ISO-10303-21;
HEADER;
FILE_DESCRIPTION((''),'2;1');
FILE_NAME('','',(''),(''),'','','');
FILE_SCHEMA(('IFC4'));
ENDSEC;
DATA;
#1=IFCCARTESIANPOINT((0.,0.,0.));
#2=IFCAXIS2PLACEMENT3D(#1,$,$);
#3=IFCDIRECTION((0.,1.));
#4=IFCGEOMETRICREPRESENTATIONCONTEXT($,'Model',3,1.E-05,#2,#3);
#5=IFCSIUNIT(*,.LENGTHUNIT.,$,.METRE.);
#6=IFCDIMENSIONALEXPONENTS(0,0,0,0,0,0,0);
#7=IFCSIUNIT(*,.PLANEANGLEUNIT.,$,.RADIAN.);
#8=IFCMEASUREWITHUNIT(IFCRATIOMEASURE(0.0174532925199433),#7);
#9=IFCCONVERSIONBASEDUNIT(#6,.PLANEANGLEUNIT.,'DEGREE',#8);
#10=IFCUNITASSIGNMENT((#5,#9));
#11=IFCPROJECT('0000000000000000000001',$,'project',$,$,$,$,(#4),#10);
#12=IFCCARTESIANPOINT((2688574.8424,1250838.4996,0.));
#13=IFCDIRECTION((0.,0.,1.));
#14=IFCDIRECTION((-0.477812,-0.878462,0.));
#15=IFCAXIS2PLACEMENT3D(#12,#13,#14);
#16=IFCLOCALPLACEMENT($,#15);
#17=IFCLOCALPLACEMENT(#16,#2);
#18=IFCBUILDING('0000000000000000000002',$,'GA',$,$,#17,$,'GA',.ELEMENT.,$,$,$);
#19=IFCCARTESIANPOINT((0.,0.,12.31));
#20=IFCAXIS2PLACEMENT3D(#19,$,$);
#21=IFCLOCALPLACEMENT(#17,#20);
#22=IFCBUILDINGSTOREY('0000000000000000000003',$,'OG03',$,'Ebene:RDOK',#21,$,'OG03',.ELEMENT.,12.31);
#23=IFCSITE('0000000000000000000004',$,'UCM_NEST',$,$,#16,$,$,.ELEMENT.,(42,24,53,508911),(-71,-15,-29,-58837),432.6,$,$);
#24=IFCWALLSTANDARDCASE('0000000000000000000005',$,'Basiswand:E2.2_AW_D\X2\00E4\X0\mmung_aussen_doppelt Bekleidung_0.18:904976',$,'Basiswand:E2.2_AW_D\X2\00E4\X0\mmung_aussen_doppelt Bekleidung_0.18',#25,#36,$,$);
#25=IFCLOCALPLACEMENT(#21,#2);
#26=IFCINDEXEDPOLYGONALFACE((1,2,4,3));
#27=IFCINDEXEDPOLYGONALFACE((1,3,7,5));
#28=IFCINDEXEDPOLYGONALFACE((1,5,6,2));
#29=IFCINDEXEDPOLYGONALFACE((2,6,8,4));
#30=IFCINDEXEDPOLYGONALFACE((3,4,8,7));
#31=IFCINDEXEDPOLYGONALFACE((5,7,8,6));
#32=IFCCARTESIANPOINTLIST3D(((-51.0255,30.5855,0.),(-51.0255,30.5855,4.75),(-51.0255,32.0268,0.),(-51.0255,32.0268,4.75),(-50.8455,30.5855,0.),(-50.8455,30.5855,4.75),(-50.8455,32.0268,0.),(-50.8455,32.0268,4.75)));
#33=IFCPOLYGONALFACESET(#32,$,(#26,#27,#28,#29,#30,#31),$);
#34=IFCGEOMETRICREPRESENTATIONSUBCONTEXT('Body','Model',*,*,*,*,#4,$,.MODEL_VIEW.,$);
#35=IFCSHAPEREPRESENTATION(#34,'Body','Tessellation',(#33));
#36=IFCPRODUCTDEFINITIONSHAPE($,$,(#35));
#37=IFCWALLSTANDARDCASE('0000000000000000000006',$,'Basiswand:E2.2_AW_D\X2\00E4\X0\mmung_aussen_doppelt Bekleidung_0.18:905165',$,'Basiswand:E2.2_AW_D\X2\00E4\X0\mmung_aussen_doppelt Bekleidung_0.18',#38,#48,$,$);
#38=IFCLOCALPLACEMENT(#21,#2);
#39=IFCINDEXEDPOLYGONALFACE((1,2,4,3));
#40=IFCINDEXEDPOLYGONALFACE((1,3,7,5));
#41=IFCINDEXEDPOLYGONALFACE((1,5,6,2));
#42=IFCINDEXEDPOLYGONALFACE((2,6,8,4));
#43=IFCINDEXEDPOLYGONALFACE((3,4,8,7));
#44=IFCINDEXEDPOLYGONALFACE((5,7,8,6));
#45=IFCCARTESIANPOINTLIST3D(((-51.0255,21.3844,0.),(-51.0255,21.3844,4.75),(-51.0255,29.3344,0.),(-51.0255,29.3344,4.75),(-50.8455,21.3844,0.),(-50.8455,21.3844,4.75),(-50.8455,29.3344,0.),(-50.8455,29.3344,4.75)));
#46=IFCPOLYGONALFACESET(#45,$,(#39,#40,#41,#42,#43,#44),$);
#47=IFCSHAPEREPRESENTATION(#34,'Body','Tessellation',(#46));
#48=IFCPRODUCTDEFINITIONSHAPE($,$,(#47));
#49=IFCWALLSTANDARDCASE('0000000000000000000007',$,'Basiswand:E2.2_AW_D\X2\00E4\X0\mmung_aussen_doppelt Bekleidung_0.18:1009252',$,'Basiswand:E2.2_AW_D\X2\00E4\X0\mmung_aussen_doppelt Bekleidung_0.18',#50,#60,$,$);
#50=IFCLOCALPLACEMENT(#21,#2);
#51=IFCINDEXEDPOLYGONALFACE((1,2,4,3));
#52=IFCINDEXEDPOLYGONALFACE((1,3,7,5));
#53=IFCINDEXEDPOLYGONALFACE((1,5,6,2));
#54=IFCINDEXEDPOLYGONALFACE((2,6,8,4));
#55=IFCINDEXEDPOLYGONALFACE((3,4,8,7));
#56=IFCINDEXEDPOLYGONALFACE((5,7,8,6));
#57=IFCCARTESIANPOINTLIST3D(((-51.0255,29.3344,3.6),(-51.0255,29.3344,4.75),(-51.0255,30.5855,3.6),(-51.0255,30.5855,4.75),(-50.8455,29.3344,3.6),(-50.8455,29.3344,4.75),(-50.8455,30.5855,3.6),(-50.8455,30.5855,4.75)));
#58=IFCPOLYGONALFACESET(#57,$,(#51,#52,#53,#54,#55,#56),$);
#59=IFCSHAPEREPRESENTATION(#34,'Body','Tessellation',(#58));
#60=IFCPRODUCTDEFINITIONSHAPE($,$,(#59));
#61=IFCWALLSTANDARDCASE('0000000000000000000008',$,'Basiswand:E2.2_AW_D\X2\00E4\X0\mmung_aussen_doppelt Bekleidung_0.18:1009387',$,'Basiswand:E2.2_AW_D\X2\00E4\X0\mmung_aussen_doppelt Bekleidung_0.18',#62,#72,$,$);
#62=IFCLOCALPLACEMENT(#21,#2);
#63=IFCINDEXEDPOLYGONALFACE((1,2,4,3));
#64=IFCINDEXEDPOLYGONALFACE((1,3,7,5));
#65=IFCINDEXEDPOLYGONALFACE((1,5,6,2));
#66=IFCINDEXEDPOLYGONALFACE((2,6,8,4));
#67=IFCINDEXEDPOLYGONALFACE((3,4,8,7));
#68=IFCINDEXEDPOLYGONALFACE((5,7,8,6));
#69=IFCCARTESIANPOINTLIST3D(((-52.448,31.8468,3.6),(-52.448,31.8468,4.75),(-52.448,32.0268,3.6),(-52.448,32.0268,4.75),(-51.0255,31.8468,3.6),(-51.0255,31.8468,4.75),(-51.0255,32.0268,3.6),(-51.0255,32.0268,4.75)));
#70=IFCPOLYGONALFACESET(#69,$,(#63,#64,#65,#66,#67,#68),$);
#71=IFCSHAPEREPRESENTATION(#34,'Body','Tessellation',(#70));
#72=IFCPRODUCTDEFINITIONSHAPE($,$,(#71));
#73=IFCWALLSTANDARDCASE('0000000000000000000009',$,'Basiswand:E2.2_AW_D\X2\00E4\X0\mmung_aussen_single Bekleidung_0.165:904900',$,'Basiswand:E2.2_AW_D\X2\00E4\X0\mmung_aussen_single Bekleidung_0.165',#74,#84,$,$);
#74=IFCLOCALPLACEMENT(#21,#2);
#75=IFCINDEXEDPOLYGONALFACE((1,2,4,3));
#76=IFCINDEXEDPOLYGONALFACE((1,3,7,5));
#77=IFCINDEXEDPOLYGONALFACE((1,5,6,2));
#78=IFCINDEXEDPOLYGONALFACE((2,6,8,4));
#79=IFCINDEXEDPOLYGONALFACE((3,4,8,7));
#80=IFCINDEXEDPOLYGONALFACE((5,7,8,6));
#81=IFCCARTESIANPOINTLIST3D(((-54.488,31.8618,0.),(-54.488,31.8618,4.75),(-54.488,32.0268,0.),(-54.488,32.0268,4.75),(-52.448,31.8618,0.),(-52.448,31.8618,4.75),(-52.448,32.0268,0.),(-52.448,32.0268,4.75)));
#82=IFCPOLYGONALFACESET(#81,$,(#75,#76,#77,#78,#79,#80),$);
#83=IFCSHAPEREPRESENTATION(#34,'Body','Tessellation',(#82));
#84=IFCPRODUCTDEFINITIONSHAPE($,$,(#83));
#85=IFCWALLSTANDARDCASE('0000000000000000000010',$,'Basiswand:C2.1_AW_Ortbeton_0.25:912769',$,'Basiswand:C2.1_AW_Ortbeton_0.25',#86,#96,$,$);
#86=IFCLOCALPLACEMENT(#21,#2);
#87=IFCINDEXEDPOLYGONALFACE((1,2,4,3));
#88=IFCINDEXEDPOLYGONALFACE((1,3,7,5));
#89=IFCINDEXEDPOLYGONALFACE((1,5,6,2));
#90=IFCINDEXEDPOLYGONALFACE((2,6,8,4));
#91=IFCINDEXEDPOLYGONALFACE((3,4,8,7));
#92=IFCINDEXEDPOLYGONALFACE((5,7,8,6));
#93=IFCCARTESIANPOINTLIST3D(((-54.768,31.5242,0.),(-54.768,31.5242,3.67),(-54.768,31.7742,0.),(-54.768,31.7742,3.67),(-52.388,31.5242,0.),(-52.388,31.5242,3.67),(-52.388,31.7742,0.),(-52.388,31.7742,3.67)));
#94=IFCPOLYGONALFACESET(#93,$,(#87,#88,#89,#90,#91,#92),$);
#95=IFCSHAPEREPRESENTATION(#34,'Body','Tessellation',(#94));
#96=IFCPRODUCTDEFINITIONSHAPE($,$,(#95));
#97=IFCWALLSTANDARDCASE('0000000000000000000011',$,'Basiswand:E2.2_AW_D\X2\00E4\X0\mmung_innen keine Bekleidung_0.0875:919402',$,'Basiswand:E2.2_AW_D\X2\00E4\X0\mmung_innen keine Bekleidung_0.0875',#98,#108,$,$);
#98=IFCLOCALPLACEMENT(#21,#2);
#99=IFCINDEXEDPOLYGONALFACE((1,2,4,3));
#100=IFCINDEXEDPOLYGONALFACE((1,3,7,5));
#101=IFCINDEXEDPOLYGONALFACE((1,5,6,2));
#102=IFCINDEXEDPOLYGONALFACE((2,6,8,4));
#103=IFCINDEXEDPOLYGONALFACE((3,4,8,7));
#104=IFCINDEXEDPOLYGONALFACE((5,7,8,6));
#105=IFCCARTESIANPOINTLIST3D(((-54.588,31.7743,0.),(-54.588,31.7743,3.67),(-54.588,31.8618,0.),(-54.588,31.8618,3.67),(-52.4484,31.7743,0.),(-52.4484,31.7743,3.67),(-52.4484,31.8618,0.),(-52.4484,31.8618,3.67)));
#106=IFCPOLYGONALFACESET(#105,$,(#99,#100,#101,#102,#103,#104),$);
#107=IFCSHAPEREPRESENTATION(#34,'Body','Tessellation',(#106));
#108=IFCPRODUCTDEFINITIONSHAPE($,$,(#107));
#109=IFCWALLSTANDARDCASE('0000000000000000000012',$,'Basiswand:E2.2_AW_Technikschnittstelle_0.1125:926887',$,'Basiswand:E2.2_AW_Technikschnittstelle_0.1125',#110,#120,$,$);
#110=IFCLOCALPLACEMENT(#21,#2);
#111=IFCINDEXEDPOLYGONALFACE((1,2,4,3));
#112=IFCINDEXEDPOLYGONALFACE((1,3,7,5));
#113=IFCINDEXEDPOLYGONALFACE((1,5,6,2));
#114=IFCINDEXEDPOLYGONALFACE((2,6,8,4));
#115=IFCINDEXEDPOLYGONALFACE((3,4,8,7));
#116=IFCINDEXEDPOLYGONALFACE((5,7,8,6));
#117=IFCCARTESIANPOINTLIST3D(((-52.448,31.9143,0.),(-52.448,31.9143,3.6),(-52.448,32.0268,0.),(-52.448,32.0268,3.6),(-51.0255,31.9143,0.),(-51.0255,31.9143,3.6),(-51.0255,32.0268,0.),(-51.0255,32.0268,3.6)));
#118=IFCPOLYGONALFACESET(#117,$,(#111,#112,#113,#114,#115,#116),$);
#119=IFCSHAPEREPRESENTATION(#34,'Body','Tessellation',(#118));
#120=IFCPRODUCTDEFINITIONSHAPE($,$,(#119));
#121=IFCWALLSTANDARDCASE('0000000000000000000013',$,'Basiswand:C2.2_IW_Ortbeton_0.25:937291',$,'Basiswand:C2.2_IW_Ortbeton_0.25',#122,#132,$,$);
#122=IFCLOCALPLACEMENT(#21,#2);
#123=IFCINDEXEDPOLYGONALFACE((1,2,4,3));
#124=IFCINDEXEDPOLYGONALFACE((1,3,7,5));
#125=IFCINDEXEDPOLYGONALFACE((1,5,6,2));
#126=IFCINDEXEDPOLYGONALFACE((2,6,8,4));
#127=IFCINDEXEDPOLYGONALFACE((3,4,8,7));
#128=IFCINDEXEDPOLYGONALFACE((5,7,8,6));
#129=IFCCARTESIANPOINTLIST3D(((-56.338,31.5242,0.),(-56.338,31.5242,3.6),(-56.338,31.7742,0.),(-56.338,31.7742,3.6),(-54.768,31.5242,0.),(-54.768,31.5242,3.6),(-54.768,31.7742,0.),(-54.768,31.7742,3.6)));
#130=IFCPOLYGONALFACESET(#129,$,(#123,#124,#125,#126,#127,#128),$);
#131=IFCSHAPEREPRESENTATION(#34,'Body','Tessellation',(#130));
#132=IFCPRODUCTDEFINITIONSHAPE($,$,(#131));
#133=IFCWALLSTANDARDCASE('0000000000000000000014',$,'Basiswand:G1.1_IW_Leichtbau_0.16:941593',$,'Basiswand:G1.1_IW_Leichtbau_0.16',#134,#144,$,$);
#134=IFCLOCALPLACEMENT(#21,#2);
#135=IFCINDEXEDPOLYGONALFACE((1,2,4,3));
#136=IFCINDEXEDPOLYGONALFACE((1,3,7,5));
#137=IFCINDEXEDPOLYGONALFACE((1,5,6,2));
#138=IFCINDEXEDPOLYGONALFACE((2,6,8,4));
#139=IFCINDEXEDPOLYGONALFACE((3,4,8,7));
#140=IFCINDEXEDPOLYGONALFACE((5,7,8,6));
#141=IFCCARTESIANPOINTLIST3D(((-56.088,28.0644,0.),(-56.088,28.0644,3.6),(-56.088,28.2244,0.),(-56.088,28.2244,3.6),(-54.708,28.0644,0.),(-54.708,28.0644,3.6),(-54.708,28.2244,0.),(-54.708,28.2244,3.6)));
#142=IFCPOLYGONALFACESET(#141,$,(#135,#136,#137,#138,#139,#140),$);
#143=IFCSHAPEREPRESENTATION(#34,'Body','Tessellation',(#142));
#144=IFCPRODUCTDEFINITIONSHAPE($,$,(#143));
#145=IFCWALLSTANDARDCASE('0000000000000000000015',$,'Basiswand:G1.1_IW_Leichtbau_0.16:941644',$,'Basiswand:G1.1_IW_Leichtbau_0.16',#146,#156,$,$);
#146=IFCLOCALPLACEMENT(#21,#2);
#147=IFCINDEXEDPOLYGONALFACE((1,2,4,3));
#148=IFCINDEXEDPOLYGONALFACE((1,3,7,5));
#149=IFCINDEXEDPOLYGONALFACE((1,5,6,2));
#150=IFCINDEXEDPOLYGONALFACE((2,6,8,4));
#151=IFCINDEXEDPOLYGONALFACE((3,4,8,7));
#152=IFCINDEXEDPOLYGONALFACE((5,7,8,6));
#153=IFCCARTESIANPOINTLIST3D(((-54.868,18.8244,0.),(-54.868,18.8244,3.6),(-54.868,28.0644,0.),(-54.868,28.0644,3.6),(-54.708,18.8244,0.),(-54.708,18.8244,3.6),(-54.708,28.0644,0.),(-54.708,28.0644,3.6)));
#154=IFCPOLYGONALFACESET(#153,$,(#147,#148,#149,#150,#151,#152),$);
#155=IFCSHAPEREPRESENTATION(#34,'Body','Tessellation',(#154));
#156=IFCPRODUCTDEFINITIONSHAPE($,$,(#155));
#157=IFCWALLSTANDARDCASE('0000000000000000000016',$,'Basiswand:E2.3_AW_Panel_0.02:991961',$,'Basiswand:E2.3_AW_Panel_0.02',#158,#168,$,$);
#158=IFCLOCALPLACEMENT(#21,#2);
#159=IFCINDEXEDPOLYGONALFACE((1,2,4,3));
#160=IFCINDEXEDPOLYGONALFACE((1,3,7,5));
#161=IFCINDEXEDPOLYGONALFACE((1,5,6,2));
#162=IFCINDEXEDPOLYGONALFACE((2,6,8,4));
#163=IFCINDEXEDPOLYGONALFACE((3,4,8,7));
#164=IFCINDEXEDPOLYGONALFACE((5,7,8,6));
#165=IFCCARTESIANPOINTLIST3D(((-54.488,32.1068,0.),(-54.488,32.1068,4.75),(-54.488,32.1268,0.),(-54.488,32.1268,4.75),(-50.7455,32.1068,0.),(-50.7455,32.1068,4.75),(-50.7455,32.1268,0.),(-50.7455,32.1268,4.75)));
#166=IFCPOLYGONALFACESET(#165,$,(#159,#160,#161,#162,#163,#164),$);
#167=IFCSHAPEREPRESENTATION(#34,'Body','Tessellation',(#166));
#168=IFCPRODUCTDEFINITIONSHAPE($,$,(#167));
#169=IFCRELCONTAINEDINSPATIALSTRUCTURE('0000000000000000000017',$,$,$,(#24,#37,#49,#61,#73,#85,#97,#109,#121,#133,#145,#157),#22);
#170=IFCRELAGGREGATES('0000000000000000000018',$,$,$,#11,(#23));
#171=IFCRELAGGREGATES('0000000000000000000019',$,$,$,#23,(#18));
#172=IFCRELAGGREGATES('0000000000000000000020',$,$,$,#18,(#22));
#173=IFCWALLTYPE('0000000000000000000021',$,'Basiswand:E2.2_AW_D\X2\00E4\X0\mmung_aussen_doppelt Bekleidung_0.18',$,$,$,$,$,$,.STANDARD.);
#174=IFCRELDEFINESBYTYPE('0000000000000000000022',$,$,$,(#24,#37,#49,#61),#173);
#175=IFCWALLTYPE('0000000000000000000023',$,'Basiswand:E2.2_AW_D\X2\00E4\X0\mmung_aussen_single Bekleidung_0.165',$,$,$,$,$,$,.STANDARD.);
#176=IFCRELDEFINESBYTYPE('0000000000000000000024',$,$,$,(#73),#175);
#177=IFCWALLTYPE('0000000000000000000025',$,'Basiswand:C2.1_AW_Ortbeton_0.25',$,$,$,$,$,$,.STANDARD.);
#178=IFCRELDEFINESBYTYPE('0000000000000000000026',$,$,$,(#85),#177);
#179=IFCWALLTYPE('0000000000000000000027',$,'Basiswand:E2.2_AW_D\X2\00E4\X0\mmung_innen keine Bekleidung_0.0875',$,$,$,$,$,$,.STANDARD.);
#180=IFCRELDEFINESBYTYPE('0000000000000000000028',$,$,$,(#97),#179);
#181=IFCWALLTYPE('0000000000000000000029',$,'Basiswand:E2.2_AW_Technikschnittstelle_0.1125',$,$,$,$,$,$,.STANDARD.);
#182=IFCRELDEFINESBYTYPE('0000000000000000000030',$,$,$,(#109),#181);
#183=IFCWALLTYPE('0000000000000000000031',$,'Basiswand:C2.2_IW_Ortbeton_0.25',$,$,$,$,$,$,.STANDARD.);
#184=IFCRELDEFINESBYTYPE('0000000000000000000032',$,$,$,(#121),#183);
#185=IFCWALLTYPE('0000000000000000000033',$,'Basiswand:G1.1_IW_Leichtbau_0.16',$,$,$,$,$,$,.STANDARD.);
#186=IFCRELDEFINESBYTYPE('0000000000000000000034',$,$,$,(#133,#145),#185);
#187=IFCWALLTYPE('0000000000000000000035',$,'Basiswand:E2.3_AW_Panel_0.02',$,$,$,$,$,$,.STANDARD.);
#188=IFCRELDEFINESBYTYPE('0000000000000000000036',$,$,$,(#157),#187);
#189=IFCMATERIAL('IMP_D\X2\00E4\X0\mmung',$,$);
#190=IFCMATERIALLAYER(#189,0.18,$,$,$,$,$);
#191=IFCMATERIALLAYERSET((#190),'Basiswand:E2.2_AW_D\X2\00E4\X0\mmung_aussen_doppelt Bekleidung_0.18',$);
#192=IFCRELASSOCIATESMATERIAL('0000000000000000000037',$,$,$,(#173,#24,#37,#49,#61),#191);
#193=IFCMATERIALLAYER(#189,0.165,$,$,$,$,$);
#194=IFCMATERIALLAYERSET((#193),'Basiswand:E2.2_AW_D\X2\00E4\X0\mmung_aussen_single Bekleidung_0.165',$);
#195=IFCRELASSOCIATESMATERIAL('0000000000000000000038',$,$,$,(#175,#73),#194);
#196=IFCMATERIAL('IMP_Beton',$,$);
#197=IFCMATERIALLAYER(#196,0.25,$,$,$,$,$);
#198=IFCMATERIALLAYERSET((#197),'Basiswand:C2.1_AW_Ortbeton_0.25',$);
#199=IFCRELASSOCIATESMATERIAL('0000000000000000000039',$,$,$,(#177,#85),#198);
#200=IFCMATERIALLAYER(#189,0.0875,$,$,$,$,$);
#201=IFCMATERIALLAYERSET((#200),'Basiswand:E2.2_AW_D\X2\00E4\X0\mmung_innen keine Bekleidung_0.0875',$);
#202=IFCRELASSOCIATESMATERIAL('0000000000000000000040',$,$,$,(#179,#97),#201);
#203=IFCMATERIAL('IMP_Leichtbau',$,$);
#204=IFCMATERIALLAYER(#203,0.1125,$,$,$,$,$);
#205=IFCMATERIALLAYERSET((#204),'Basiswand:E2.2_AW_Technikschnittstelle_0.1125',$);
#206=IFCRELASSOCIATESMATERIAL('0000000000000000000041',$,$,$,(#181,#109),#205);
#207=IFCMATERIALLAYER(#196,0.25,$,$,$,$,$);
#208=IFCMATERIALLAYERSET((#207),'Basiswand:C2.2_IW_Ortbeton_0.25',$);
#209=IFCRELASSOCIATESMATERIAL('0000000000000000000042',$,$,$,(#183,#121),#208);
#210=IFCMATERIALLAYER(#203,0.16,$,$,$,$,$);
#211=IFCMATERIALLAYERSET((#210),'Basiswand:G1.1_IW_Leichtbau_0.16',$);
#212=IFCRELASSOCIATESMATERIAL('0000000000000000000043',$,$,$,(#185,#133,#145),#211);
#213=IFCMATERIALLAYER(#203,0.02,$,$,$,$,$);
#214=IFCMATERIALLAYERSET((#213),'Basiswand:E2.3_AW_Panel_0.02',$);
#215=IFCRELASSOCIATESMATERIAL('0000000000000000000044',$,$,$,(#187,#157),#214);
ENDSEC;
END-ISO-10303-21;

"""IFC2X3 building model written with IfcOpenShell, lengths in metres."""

from ifc_helpers import new_model, entity, si_unit, converted_unit, direction, frame, frame_2d, origin, place, context, subcontext, project, spatial, rectangle, extrude, material, layer, layer_set, layer_usage, type_object, element, save


model = new_model("IFC2X3")

# Units and contexts
model_context = context("Model", 3, precision=1e-05, world=origin(), true_north=direction((0.0, 1.0)))
body_context = subcontext(model_context, "Body", "Model", "MODEL_VIEW")
ifc_project = project(units=[si_unit("LENGTHUNIT", "METRE"), converted_unit("PLANEANGLEUNIT", "DEGREE", entity("IfcRatioMeasure", 0.0174532925199433), si_unit("PLANEANGLEUNIT", "RADIAN"), dimensions=[0, 0, 0, 0, 0, 0, 0])], contexts=[model_context])

# Site, building, storey
site_placement = place(None, frame((2688574.8424, 1250838.4996, 0.0), z_axis=(0.0, 0.0, 1.0), x_axis=(-0.477812, -0.878462, 0.0)))
site = spatial("IfcSite", under=ifc_project, at=site_placement, Name="UCM_NEST", CompositionType="ELEMENT", RefLatitude=(42, 24, 53, 508911), RefLongitude=(-71, -15, -29, -58837), RefElevation=432.6)
building_placement = place(site_placement, origin())
building = spatial("IfcBuilding", under=site, at=building_placement, Name="GA", LongName="GA", CompositionType="ELEMENT")
storey_placement = place(building_placement, frame((0.0, 0.0, 12.31)))
storey = spatial("IfcBuildingStorey", under=building, at=storey_placement, Name="OG03", ObjectType="Ebene:RDOK", LongName="OG03", CompositionType="ELEMENT", Elevation=12.31)

# Walls
ifc_material_1 = material(Name="IMP_Dämmung")
ifc_layer_1 = layer(ifc_material_1, 0.18)
ifc_layer_set_1 = layer_set([ifc_layer_1], Name="Basiswand:E2.2_AW_Dämmung_aussen_doppelt Bekleidung_0.18")
ifc_layer_usage_1 = layer_usage(ifc_layer_set_1, "AXIS2", "NEGATIVE", 0.09)
wall_type_1 = type_object("IfcWallType", Name="Basiswand:E2.2_AW_Dämmung_aussen_doppelt Bekleidung_0.18", PredefinedType="STANDARD", material=ifc_layer_set_1)
wall_1_placement = place(storey_placement, frame((-50.9355, 32.0268, 0.0), z_axis=(0.0, 0.0, 1.0), x_axis=(0.0, -1.0, 0.0)))
element("IfcWallStandardCase", 1, at=wall_1_placement, inside=storey, type_object=wall_type_1, material=ifc_layer_usage_1, Name="Basiswand:E2.2_AW_Dämmung_aussen_doppelt Bekleidung_0.18:904976", ObjectType="Basiswand:E2.2_AW_Dämmung_aussen_doppelt Bekleidung_0.18", context=body_context, shape_type="SweptSolid", body=[
    extrude(rectangle(XDim=1.4412, YDim=0.18, at=frame_2d((0.7206, 0.0), x_axis=(-1.0, 0.0))), origin(), (0.0, 0.0, 1.0), 4.75),
])
ifc_layer_usage_2 = layer_usage(ifc_layer_set_1, "AXIS2", "NEGATIVE", 0.09)
wall_2_placement = place(storey_placement, frame((-50.9355, 29.3344, 0.0), z_axis=(0.0, 0.0, 1.0), x_axis=(0.0, -1.0, 0.0)))
element("IfcWallStandardCase", 2, at=wall_2_placement, inside=storey, type_object=wall_type_1, material=ifc_layer_usage_2, Name="Basiswand:E2.2_AW_Dämmung_aussen_doppelt Bekleidung_0.18:905165", ObjectType="Basiswand:E2.2_AW_Dämmung_aussen_doppelt Bekleidung_0.18", context=body_context, shape_type="SweptSolid", body=[
    extrude(rectangle(XDim=7.95, YDim=0.18, at=frame_2d((3.975, 0.0), x_axis=(-1.0, 0.0))), origin(), (0.0, 0.0, 1.0), 4.75),
])
ifc_layer_usage_3 = layer_usage(ifc_layer_set_1, "AXIS2", "NEGATIVE", 0.09)
wall_3_placement = place(storey_placement, frame((-50.9355, 29.3344, 3.6), z_axis=(0.0, 0.0, 1.0), x_axis=(0.0, 1.0, 0.0)))
element("IfcWallStandardCase", 3, at=wall_3_placement, inside=storey, type_object=wall_type_1, material=ifc_layer_usage_3, Name="Basiswand:E2.2_AW_Dämmung_aussen_doppelt Bekleidung_0.18:1009252", ObjectType="Basiswand:E2.2_AW_Dämmung_aussen_doppelt Bekleidung_0.18", context=body_context, shape_type="SweptSolid", body=[
    extrude(rectangle(XDim=1.2511, YDim=0.18, at=frame_2d((0.6256, 0.0), x_axis=(-1.0, 0.0))), origin(), (0.0, 0.0, 1.0), 1.15),
])
ifc_layer_usage_4 = layer_usage(ifc_layer_set_1, "AXIS2", "NEGATIVE", 0.09)
wall_4_placement = place(storey_placement, frame((-51.0255, 31.9368, 3.6), z_axis=(0.0, 0.0, 1.0), x_axis=(-1.0, 0.0, 0.0)))
element("IfcWallStandardCase", 4, at=wall_4_placement, inside=storey, type_object=wall_type_1, material=ifc_layer_usage_4, Name="Basiswand:E2.2_AW_Dämmung_aussen_doppelt Bekleidung_0.18:1009387", ObjectType="Basiswand:E2.2_AW_Dämmung_aussen_doppelt Bekleidung_0.18", context=body_context, shape_type="SweptSolid", body=[
    extrude(rectangle(XDim=1.4225, YDim=0.18, at=frame_2d((0.7112, 0.0), x_axis=(-1.0, 0.0))), origin(), (0.0, 0.0, 1.0), 1.15),
])
ifc_layer_2 = layer(ifc_material_1, 0.165)
ifc_layer_set_2 = layer_set([ifc_layer_2], Name="Basiswand:E2.2_AW_Dämmung_aussen_single Bekleidung_0.165")
ifc_layer_usage_5 = layer_usage(ifc_layer_set_2, "AXIS2", "NEGATIVE", 0.0825)
wall_type_2 = type_object("IfcWallType", Name="Basiswand:E2.2_AW_Dämmung_aussen_single Bekleidung_0.165", PredefinedType="STANDARD", material=ifc_layer_set_2)
wall_5_placement = place(storey_placement, frame((-54.488, 31.9443, 0.0)))
element("IfcWallStandardCase", 5, at=wall_5_placement, inside=storey, type_object=wall_type_2, material=ifc_layer_usage_5, Name="Basiswand:E2.2_AW_Dämmung_aussen_single Bekleidung_0.165:904900", ObjectType="Basiswand:E2.2_AW_Dämmung_aussen_single Bekleidung_0.165", context=body_context, shape_type="SweptSolid", body=[
    extrude(rectangle(XDim=2.04, YDim=0.165, at=frame_2d((1.02, 0.0), x_axis=(-1.0, 0.0))), origin(), (0.0, 0.0, 1.0), 4.75),
])
ifc_material_2 = material(Name="IMP_Beton")
ifc_layer_3 = layer(ifc_material_2, 0.25)
ifc_layer_set_3 = layer_set([ifc_layer_3], Name="Basiswand:C2.1_AW_Ortbeton_0.25")
ifc_layer_usage_6 = layer_usage(ifc_layer_set_3, "AXIS2", "NEGATIVE", 0.125)
wall_type_3 = type_object("IfcWallType", Name="Basiswand:C2.1_AW_Ortbeton_0.25", PredefinedType="STANDARD", material=ifc_layer_set_3)
wall_6_placement = place(storey_placement, frame((-54.768, 31.6492, 0.0)))
element("IfcWallStandardCase", 6, at=wall_6_placement, inside=storey, type_object=wall_type_3, material=ifc_layer_usage_6, Name="Basiswand:C2.1_AW_Ortbeton_0.25:912769", ObjectType="Basiswand:C2.1_AW_Ortbeton_0.25", context=body_context, shape_type="SweptSolid", body=[
    extrude(rectangle(XDim=2.38, YDim=0.25, at=frame_2d((1.19, 0.0), x_axis=(-1.0, 0.0))), origin(), (0.0, 0.0, 1.0), 3.67),
])

# Walls
ifc_layer_4 = layer(ifc_material_1, 0.0875)
ifc_layer_set_4 = layer_set([ifc_layer_4], Name="Basiswand:E2.2_AW_Dämmung_innen keine Bekleidung_0.0875")
ifc_layer_usage_7 = layer_usage(ifc_layer_set_4, "AXIS2", "NEGATIVE", 0.0437)
wall_type_4 = type_object("IfcWallType", Name="Basiswand:E2.2_AW_Dämmung_innen keine Bekleidung_0.0875", PredefinedType="STANDARD", material=ifc_layer_set_4)
wall_7_placement = place(storey_placement, frame((-54.588, 31.818, 0.0)))
element("IfcWallStandardCase", 7, at=wall_7_placement, inside=storey, type_object=wall_type_4, material=ifc_layer_usage_7, Name="Basiswand:E2.2_AW_Dämmung_innen keine Bekleidung_0.0875:919402", ObjectType="Basiswand:E2.2_AW_Dämmung_innen keine Bekleidung_0.0875", context=body_context, shape_type="SweptSolid", body=[
    extrude(rectangle(XDim=2.1396, YDim=0.0875, at=frame_2d((1.0698, 0.0), x_axis=(-1.0, 0.0))), origin(), (0.0, 0.0, 1.0), 3.67),
])
ifc_material_3 = material(Name="IMP_Leichtbau")
ifc_layer_5 = layer(ifc_material_3, 0.1125)
ifc_layer_set_5 = layer_set([ifc_layer_5], Name="Basiswand:E2.2_AW_Technikschnittstelle_0.1125")
ifc_layer_usage_8 = layer_usage(ifc_layer_set_5, "AXIS2", "NEGATIVE", 0.0563)
wall_type_5 = type_object("IfcWallType", Name="Basiswand:E2.2_AW_Technikschnittstelle_0.1125", PredefinedType="STANDARD", material=ifc_layer_set_5)
wall_8_placement = place(storey_placement, frame((-52.448, 31.9705, 0.0)))
element("IfcWallStandardCase", 8, at=wall_8_placement, inside=storey, type_object=wall_type_5, material=ifc_layer_usage_8, Name="Basiswand:E2.2_AW_Technikschnittstelle_0.1125:926887", ObjectType="Basiswand:E2.2_AW_Technikschnittstelle_0.1125", context=body_context, shape_type="SweptSolid", body=[
    extrude(rectangle(XDim=1.4225, YDim=0.1125, at=frame_2d((0.7112, 0.0), x_axis=(-1.0, 0.0))), origin(), (0.0, 0.0, 1.0), 3.6),
])
ifc_layer_6 = layer(ifc_material_2, 0.25)
ifc_layer_set_6 = layer_set([ifc_layer_6], Name="Basiswand:C2.2_IW_Ortbeton_0.25")
ifc_layer_usage_9 = layer_usage(ifc_layer_set_6, "AXIS2", "NEGATIVE", 0.125)
wall_type_6 = type_object("IfcWallType", Name="Basiswand:C2.2_IW_Ortbeton_0.25", PredefinedType="STANDARD", material=ifc_layer_set_6)
wall_9_placement = place(storey_placement, frame((-54.768, 31.6492, 0.0), z_axis=(0.0, 0.0, 1.0), x_axis=(-1.0, 0.0, 0.0)))
element("IfcWallStandardCase", 9, at=wall_9_placement, inside=storey, type_object=wall_type_6, material=ifc_layer_usage_9, Name="Basiswand:C2.2_IW_Ortbeton_0.25:937291", ObjectType="Basiswand:C2.2_IW_Ortbeton_0.25", context=body_context, shape_type="SweptSolid", body=[
    extrude(rectangle(XDim=1.57, YDim=0.25, at=frame_2d((0.785, 0.0), x_axis=(-1.0, 0.0))), origin(), (0.0, 0.0, 1.0), 3.6),
])
ifc_layer_7 = layer(ifc_material_3, 0.16)
ifc_layer_set_7 = layer_set([ifc_layer_7], Name="Basiswand:G1.1_IW_Leichtbau_0.16")
ifc_layer_usage_10 = layer_usage(ifc_layer_set_7, "AXIS2", "NEGATIVE", 0.08)
wall_type_7 = type_object("IfcWallType", Name="Basiswand:G1.1_IW_Leichtbau_0.16", PredefinedType="STANDARD", material=ifc_layer_set_7)
wall_10_placement = place(storey_placement, frame((-56.088, 28.1444, 0.0)))
element("IfcWallStandardCase", 10, at=wall_10_placement, inside=storey, type_object=wall_type_7, material=ifc_layer_usage_10, Name="Basiswand:G1.1_IW_Leichtbau_0.16:941593", ObjectType="Basiswand:G1.1_IW_Leichtbau_0.16", context=body_context, shape_type="SweptSolid", body=[
    extrude(rectangle(XDim=1.38, YDim=0.16, at=frame_2d((0.69, 0.0), x_axis=(-1.0, 0.0))), origin(), (0.0, 0.0, 1.0), 3.6),
])
ifc_layer_usage_11 = layer_usage(ifc_layer_set_7, "AXIS2", "NEGATIVE", 0.08)
wall_11_placement = place(storey_placement, frame((-54.788, 28.0644, 0.0), z_axis=(0.0, 0.0, 1.0), x_axis=(0.0, -1.0, 0.0)))
element("IfcWallStandardCase", 11, at=wall_11_placement, inside=storey, type_object=wall_type_7, material=ifc_layer_usage_11, Name="Basiswand:G1.1_IW_Leichtbau_0.16:941644", ObjectType="Basiswand:G1.1_IW_Leichtbau_0.16", context=body_context, shape_type="SweptSolid", body=[
    extrude(rectangle(XDim=9.24, YDim=0.16, at=frame_2d((4.62, 0.0), x_axis=(-1.0, 0.0))), origin(), (0.0, 0.0, 1.0), 3.6),
])
ifc_layer_8 = layer(ifc_material_3, 0.02)
ifc_layer_set_8 = layer_set([ifc_layer_8], Name="Basiswand:E2.3_AW_Panel_0.02")
ifc_layer_usage_12 = layer_usage(ifc_layer_set_8, "AXIS2", "NEGATIVE", 0.01)
wall_type_8 = type_object("IfcWallType", Name="Basiswand:E2.3_AW_Panel_0.02", PredefinedType="STANDARD", material=ifc_layer_set_8)
wall_12_placement = place(storey_placement, frame((-54.488, 32.1168, 0.0)))
element("IfcWallStandardCase", 12, at=wall_12_placement, inside=storey, type_object=wall_type_8, material=ifc_layer_usage_12, Name="Basiswand:E2.3_AW_Panel_0.02:991961", ObjectType="Basiswand:E2.3_AW_Panel_0.02", context=body_context, shape_type="SweptSolid", body=[
    extrude(rectangle(XDim=3.7425, YDim=0.02, at=frame_2d((1.8712, 0.0), x_axis=(-1.0, 0.0))), origin(), (0.0, 0.0, 1.0), 4.75),
])

save(model, "model.ifc")
